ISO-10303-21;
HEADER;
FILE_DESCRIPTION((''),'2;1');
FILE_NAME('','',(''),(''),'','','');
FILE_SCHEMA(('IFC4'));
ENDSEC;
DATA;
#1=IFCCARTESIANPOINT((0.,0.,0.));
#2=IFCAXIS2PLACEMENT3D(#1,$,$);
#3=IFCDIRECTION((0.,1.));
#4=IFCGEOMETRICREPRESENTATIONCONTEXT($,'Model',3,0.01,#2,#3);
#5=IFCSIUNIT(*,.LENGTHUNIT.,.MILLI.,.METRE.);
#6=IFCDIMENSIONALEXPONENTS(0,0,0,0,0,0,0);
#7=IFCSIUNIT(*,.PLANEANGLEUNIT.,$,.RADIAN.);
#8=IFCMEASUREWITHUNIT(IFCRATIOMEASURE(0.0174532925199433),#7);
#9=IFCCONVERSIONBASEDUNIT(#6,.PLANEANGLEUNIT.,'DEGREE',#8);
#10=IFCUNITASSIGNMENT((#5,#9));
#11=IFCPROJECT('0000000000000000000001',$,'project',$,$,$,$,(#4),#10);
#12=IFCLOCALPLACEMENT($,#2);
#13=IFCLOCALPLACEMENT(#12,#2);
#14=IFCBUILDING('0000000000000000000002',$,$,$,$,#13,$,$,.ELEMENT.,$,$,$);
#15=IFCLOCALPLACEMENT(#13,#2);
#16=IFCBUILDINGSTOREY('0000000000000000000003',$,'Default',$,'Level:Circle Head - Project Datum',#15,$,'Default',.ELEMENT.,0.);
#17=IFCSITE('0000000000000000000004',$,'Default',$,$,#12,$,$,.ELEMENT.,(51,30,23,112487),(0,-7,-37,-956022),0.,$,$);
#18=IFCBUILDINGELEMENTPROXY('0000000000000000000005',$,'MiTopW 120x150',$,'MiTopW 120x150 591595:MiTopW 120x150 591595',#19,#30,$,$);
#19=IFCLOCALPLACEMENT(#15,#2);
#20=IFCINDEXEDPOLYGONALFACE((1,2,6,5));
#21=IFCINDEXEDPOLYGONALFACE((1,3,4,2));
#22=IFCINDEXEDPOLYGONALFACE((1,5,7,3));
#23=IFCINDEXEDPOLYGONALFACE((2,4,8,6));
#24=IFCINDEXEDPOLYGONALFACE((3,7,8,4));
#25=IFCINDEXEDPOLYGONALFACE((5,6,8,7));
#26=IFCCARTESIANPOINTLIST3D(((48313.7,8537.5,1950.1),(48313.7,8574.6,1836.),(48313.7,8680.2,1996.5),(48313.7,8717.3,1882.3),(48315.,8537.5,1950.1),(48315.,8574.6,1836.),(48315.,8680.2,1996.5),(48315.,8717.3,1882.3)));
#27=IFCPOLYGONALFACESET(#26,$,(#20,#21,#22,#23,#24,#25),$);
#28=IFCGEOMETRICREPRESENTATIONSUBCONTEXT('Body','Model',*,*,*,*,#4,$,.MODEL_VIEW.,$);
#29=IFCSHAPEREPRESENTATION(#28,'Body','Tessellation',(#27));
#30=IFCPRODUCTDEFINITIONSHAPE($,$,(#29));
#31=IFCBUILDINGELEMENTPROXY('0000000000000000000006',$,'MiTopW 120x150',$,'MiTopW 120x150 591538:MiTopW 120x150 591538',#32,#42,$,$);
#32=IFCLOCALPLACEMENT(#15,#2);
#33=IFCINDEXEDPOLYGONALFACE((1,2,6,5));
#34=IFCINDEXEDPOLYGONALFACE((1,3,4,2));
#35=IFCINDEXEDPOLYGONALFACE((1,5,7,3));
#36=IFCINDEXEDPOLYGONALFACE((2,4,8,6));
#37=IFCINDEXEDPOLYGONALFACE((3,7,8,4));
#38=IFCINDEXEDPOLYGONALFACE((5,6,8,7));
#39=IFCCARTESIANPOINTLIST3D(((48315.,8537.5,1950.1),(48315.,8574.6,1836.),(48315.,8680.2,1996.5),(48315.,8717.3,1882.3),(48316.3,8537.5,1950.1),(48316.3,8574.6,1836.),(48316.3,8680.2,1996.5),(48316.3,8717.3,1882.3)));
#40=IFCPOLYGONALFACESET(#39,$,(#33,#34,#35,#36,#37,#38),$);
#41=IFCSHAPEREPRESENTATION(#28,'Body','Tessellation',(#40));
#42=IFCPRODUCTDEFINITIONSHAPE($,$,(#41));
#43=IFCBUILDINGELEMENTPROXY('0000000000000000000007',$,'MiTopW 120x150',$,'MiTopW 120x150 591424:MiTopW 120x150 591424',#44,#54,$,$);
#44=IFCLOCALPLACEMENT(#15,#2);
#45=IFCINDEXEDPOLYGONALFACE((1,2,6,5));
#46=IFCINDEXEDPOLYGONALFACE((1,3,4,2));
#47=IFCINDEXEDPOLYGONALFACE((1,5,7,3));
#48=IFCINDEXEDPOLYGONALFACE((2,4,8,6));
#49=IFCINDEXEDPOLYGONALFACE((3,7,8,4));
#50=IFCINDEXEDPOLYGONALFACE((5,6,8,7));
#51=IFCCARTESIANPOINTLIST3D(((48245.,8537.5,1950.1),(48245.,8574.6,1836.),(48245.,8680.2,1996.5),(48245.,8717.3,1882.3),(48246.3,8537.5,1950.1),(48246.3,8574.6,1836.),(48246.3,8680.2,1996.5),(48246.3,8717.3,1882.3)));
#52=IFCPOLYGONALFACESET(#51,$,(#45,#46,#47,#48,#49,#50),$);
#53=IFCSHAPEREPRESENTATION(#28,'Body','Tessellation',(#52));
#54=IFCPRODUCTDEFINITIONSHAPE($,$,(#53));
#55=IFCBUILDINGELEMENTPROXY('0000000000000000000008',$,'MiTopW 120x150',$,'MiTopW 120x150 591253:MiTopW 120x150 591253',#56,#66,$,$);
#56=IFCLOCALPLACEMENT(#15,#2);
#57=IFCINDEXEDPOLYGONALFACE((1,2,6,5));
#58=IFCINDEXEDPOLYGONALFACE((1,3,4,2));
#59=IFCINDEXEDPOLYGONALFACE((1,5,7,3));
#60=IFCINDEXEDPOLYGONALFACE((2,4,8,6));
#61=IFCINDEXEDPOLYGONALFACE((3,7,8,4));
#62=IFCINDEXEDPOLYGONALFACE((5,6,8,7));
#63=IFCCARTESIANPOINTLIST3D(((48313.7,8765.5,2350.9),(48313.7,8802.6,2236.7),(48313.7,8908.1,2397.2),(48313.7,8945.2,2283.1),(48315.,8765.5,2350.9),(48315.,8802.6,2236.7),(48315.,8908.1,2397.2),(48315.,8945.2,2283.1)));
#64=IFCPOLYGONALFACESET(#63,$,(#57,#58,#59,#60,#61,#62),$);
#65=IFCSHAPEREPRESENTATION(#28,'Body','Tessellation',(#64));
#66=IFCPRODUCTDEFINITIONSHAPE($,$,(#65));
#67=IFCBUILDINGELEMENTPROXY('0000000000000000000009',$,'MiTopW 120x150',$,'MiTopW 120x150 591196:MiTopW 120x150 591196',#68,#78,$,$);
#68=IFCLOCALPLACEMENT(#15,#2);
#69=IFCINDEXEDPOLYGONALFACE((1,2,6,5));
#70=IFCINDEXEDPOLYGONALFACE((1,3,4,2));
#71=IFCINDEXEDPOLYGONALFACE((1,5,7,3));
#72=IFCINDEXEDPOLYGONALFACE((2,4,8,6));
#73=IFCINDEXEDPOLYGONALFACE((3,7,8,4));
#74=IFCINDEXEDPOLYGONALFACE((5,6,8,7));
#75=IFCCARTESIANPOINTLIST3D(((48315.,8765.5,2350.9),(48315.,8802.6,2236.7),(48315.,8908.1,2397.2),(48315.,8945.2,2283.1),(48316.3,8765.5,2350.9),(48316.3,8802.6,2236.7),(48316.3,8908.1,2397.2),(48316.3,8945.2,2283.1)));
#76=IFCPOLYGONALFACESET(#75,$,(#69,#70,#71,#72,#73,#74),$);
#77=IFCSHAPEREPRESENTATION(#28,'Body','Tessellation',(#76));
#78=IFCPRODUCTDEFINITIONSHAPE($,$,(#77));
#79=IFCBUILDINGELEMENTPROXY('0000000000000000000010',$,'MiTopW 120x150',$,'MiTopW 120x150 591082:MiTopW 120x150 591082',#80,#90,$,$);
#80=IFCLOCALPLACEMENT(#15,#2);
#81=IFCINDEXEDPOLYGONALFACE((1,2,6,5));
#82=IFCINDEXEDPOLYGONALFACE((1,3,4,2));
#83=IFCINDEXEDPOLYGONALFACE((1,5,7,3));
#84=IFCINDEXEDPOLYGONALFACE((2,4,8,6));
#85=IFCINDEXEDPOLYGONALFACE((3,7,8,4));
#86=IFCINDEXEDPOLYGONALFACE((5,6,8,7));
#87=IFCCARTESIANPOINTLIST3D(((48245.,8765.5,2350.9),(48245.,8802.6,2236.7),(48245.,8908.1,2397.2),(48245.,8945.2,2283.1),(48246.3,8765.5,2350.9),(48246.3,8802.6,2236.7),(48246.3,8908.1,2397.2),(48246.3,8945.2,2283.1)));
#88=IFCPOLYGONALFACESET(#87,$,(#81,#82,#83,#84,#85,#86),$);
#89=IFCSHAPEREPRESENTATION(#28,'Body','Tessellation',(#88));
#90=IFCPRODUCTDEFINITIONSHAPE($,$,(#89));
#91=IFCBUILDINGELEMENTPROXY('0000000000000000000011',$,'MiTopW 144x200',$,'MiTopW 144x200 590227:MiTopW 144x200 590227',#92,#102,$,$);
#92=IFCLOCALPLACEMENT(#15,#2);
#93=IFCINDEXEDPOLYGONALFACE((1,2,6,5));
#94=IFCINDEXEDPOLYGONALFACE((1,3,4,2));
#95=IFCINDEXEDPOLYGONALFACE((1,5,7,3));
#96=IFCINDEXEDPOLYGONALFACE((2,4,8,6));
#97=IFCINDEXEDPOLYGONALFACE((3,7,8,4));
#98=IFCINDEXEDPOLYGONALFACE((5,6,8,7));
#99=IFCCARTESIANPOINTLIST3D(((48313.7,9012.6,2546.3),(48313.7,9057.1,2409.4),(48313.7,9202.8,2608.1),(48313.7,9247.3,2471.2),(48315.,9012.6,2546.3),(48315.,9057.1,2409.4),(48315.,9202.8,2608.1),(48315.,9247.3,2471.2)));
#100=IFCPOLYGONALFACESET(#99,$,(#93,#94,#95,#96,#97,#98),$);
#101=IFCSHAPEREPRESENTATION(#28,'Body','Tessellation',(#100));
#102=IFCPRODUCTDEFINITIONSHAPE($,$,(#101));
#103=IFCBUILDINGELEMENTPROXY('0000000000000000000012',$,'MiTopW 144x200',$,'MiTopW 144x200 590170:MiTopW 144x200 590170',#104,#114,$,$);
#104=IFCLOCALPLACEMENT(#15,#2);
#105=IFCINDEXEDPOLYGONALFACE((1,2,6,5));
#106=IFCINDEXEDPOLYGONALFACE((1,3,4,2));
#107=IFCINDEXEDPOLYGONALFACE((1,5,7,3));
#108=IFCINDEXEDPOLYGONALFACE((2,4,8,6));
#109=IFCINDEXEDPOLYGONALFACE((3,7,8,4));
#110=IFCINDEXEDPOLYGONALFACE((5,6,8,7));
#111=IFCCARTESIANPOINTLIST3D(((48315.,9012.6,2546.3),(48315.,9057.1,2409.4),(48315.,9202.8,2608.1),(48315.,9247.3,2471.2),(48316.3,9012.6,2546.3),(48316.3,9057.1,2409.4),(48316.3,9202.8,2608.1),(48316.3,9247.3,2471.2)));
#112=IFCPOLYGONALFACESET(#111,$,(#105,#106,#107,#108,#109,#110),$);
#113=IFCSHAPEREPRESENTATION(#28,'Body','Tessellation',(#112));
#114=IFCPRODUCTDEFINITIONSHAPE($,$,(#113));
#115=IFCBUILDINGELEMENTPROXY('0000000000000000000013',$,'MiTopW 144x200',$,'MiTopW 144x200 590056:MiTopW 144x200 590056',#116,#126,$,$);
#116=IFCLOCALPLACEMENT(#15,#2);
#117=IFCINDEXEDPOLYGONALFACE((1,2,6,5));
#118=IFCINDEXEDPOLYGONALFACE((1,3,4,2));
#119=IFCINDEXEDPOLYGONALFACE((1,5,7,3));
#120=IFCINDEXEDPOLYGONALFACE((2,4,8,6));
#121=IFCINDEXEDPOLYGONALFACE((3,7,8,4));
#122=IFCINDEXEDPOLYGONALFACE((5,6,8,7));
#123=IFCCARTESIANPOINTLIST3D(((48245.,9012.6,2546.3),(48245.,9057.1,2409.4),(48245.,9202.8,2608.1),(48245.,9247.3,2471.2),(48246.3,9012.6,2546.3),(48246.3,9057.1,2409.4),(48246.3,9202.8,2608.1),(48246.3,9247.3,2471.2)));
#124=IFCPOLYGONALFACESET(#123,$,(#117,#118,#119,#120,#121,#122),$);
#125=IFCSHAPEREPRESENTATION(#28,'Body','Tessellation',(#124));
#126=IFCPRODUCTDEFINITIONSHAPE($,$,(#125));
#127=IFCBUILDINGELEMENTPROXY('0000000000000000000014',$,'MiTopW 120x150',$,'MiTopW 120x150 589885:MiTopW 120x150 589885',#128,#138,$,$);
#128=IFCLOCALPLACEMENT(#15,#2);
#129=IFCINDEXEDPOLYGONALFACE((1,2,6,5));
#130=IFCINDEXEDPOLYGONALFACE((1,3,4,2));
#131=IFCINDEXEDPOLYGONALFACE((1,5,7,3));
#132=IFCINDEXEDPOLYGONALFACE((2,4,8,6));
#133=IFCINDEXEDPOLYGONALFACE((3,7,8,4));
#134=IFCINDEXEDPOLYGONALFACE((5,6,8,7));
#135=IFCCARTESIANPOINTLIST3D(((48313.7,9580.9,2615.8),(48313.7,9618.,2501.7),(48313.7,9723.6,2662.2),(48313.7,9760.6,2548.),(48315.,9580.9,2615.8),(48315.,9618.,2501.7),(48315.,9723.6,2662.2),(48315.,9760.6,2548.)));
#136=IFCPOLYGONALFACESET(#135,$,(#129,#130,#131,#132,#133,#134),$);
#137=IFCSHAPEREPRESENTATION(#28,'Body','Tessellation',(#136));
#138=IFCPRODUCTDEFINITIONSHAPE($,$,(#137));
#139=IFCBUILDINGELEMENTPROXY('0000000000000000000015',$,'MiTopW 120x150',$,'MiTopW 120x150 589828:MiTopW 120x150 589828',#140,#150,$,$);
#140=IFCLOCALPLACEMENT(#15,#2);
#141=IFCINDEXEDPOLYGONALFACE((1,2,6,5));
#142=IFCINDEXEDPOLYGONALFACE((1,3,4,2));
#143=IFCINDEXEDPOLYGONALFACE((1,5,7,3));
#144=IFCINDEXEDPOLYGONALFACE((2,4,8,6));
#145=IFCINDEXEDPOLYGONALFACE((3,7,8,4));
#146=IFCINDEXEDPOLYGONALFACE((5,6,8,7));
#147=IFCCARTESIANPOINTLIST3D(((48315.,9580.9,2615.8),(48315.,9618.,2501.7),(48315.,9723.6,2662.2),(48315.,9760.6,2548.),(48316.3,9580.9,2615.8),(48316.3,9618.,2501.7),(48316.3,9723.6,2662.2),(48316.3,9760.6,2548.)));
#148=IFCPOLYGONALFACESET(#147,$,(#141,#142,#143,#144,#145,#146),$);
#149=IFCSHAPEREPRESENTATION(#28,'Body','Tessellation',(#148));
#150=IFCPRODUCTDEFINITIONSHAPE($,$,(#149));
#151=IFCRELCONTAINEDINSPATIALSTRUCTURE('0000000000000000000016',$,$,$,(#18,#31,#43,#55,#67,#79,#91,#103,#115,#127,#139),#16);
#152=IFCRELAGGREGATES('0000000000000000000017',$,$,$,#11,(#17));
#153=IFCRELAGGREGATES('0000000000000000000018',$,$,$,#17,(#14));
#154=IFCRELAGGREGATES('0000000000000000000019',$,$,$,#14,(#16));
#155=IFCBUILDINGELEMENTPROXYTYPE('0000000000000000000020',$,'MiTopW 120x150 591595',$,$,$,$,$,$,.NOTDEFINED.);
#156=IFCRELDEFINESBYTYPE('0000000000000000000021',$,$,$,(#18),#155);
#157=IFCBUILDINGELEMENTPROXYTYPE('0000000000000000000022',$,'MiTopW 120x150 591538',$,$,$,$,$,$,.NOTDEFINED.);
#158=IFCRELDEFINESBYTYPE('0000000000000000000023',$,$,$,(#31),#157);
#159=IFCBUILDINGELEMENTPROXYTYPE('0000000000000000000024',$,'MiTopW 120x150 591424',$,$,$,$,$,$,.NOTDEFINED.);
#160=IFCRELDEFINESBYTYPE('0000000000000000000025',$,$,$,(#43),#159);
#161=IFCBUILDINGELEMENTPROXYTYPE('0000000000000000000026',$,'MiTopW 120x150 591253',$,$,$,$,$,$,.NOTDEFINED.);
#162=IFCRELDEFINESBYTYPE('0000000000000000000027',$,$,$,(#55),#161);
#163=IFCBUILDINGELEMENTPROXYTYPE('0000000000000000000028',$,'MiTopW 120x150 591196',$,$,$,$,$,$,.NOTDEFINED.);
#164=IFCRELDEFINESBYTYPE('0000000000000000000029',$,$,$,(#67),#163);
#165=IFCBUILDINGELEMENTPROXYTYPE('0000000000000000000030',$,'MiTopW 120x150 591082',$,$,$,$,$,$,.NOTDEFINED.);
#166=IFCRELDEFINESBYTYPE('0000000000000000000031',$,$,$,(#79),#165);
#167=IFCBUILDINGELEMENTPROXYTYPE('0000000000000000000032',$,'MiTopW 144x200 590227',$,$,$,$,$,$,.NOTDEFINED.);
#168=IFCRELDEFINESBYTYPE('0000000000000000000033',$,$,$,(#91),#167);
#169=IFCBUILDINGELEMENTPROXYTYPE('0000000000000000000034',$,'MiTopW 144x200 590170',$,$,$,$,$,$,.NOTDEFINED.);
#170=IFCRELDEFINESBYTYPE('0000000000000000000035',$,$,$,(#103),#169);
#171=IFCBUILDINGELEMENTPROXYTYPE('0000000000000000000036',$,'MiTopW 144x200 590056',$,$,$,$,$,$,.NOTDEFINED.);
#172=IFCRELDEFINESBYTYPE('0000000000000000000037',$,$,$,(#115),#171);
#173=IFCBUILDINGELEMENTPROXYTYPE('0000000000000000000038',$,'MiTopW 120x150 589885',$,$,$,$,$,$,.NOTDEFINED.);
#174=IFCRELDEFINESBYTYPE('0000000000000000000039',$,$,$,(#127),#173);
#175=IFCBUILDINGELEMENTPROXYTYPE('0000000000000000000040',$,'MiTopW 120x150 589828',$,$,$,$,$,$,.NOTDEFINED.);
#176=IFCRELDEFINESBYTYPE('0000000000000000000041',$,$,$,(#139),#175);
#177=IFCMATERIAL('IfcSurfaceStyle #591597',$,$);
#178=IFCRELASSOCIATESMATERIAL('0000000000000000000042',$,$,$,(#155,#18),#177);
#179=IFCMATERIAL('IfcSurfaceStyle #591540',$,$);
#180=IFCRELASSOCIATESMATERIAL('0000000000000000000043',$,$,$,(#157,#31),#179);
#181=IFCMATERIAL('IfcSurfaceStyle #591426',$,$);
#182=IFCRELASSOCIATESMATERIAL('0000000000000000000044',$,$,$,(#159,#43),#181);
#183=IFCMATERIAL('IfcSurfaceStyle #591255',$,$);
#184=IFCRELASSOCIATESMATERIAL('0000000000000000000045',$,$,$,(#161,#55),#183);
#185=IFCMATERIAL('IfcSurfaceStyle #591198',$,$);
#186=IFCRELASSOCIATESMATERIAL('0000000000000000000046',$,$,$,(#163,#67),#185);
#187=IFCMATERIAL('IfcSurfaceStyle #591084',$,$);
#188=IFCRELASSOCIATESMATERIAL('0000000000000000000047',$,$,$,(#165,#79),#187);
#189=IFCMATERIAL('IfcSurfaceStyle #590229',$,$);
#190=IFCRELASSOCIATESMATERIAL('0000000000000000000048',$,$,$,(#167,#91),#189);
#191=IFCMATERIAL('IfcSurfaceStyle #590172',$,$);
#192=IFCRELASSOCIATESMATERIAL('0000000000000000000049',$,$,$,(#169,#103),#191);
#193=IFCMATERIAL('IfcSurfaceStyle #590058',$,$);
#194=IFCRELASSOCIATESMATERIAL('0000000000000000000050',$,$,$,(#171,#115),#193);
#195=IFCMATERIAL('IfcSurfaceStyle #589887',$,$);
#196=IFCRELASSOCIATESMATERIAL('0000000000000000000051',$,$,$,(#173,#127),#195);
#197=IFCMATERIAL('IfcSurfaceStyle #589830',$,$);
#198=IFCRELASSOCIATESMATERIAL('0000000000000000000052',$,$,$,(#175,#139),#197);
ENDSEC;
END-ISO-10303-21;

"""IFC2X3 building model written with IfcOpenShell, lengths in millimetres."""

from ifc_helpers import new_model, entity, si_unit, converted_unit, direction, frame, origin, place, context, subcontext, project, spatial, polyline, outline, extrude, source, transform, mapped, material, type_object, type_shapes, element, save


model = new_model("IFC2X3")

# Units and contexts
model_context = context("Model", 3, precision=0.01, world=origin(), true_north=direction((0.0, 1.0)))
body_context = subcontext(model_context, "Body", "Model", "MODEL_VIEW")
ifc_project = project(units=[si_unit("LENGTHUNIT", "METRE", prefix="MILLI"), converted_unit("PLANEANGLEUNIT", "DEGREE", entity("IfcRatioMeasure", 0.0174532925199433), si_unit("PLANEANGLEUNIT", "RADIAN"), dimensions=[0, 0, 0, 0, 0, 0, 0])], contexts=[model_context])

# Site, building, storey
site_placement = place(None, origin())
site = spatial("IfcSite", under=ifc_project, at=site_placement, Name="Default", CompositionType="ELEMENT", RefLatitude=(51, 30, 23, 112487), RefLongitude=(0, -7, -37, -956022), RefElevation=0.0)
building_placement = place(site_placement, origin())
building = spatial("IfcBuilding", under=site, at=building_placement, CompositionType="ELEMENT")
storey_placement = place(building_placement, origin())
storey = spatial("IfcBuildingStorey", under=building, at=storey_placement, Name="Default", ObjectType="Level:Circle Head - Project Datum", LongName="Default", CompositionType="ELEMENT", Elevation=0.0)

# Building element proxies
ifc_material_1 = material(Name="IfcSurfaceStyle #591597")
building_element_proxy_type_1 = type_object("IfcBuildingElementProxyType", Name="MiTopW 120x150 591595", PredefinedType="NOTDEFINED", material=ifc_material_1)
shared_shape_1 = source(origin(), body_context, "Body", "SweptSolid", [
    extrude(outline(polyline([(-75.0, -60.0), (75.0, -60.0), (75.0, 60.0), (-75.0, 60.0), (-75.0, -60.0)])), frame((75.0, 60.0, 0.0), z_axis=(0.0, 0.0, 1.0), x_axis=(-1.0, 0.0, 0.0)), (0.0, 0.0, 1.0), 1.3),
])
type_shapes(building_element_proxy_type_1, [shared_shape_1])
proxy_1_placement = place(building_placement, frame((48315.0, 8537.5, 1950.1), z_axis=(-1.0, 0.0, 0.0), x_axis=(0.0, 0.951057, 0.309017)))
element("IfcBuildingElementProxy", 1, at=proxy_1_placement, inside=storey, type_object=building_element_proxy_type_1, material=ifc_material_1, Name="MiTopW 120x150", ObjectType="MiTopW 120x150 591595:MiTopW 120x150 591595", context=body_context, shape_type="MappedRepresentation", body=[
    mapped(shared_shape_1, transform((0.0, 0.0, 0.0), scale=1.0)),
])
ifc_material_2 = material(Name="IfcSurfaceStyle #591540")
building_element_proxy_type_2 = type_object("IfcBuildingElementProxyType", Name="MiTopW 120x150 591538", PredefinedType="NOTDEFINED", material=ifc_material_2)
shared_shape_2 = source(origin(), body_context, "Body", "SweptSolid", [
    extrude(outline(polyline([(-75.0, -60.0), (75.0, -60.0), (75.0, 60.0), (-75.0, 60.0), (-75.0, -60.0)])), frame((75.0, 60.0, 0.0), z_axis=(0.0, 0.0, 1.0), x_axis=(-1.0, 0.0, 0.0)), (0.0, 0.0, 1.0), 1.3),
])
type_shapes(building_element_proxy_type_2, [shared_shape_2])
proxy_2_placement = place(building_placement, frame((48316.3, 8537.5, 1950.1), z_axis=(-1.0, 0.0, 0.0), x_axis=(0.0, 0.951057, 0.309017)))
element("IfcBuildingElementProxy", 2, at=proxy_2_placement, inside=storey, type_object=building_element_proxy_type_2, material=ifc_material_2, Name="MiTopW 120x150", ObjectType="MiTopW 120x150 591538:MiTopW 120x150 591538", context=body_context, shape_type="MappedRepresentation", body=[
    mapped(shared_shape_2, transform((0.0, 0.0, 0.0), scale=1.0)),
])
ifc_material_3 = material(Name="IfcSurfaceStyle #591426")
building_element_proxy_type_3 = type_object("IfcBuildingElementProxyType", Name="MiTopW 120x150 591424", PredefinedType="NOTDEFINED", material=ifc_material_3)
shared_shape_3 = source(origin(), body_context, "Body", "SweptSolid", [
    extrude(outline(polyline([(-75.0, -60.0), (75.0, -60.0), (75.0, 60.0), (-75.0, 60.0), (-75.0, -60.0)])), frame((75.0, 60.0, 0.0), z_axis=(0.0, 0.0, 1.0), x_axis=(-1.0, 0.0, 0.0)), (0.0, 0.0, 1.0), 1.3),
])
type_shapes(building_element_proxy_type_3, [shared_shape_3])
proxy_3_placement = place(building_placement, frame((48246.3, 8537.5, 1950.1), z_axis=(-1.0, 0.0, 0.0), x_axis=(0.0, 0.951057, 0.309017)))
element("IfcBuildingElementProxy", 3, at=proxy_3_placement, inside=storey, type_object=building_element_proxy_type_3, material=ifc_material_3, Name="MiTopW 120x150", ObjectType="MiTopW 120x150 591424:MiTopW 120x150 591424", context=body_context, shape_type="MappedRepresentation", body=[
    mapped(shared_shape_3, transform((0.0, 0.0, 0.0), scale=1.0)),
])
ifc_material_4 = material(Name="IfcSurfaceStyle #591255")
building_element_proxy_type_4 = type_object("IfcBuildingElementProxyType", Name="MiTopW 120x150 591253", PredefinedType="NOTDEFINED", material=ifc_material_4)
shared_shape_4 = source(origin(), body_context, "Body", "SweptSolid", [
    extrude(outline(polyline([(-75.0, -60.0), (75.0, -60.0), (75.0, 60.0), (-75.0, 60.0), (-75.0, -60.0)])), frame((75.0, 60.0, 0.0), z_axis=(0.0, 0.0, 1.0), x_axis=(-1.0, 0.0, 0.0)), (0.0, 0.0, 1.0), 1.3),
])
type_shapes(building_element_proxy_type_4, [shared_shape_4])
proxy_4_placement = place(building_placement, frame((48315.0, 8765.5, 2350.9), z_axis=(-1.0, 0.0, 0.0), x_axis=(0.0, 0.951057, 0.309017)))
element("IfcBuildingElementProxy", 4, at=proxy_4_placement, inside=storey, type_object=building_element_proxy_type_4, material=ifc_material_4, Name="MiTopW 120x150", ObjectType="MiTopW 120x150 591253:MiTopW 120x150 591253", context=body_context, shape_type="MappedRepresentation", body=[
    mapped(shared_shape_4, transform((0.0, 0.0, 0.0), scale=1.0)),
])
ifc_material_5 = material(Name="IfcSurfaceStyle #591198")
building_element_proxy_type_5 = type_object("IfcBuildingElementProxyType", Name="MiTopW 120x150 591196", PredefinedType="NOTDEFINED", material=ifc_material_5)
shared_shape_5 = source(origin(), body_context, "Body", "SweptSolid", [
    extrude(outline(polyline([(-75.0, -60.0), (75.0, -60.0), (75.0, 60.0), (-75.0, 60.0), (-75.0, -60.0)])), frame((75.0, 60.0, 0.0), z_axis=(0.0, 0.0, 1.0), x_axis=(-1.0, 0.0, 0.0)), (0.0, 0.0, 1.0), 1.3),
])
type_shapes(building_element_proxy_type_5, [shared_shape_5])
proxy_5_placement = place(building_placement, frame((48316.3, 8765.5, 2350.9), z_axis=(-1.0, 0.0, 0.0), x_axis=(0.0, 0.951057, 0.309017)))
element("IfcBuildingElementProxy", 5, at=proxy_5_placement, inside=storey, type_object=building_element_proxy_type_5, material=ifc_material_5, Name="MiTopW 120x150", ObjectType="MiTopW 120x150 591196:MiTopW 120x150 591196", context=body_context, shape_type="MappedRepresentation", body=[
    mapped(shared_shape_5, transform((0.0, 0.0, 0.0), scale=1.0)),
])
ifc_material_6 = material(Name="IfcSurfaceStyle #591084")
building_element_proxy_type_6 = type_object("IfcBuildingElementProxyType", Name="MiTopW 120x150 591082", PredefinedType="NOTDEFINED", material=ifc_material_6)
shared_shape_6 = source(origin(), body_context, "Body", "SweptSolid", [
    extrude(outline(polyline([(-75.0, -60.0), (75.0, -60.0), (75.0, 60.0), (-75.0, 60.0), (-75.0, -60.0)])), frame((75.0, 60.0, 0.0), z_axis=(0.0, 0.0, 1.0), x_axis=(-1.0, 0.0, 0.0)), (0.0, 0.0, 1.0), 1.3),
])
type_shapes(building_element_proxy_type_6, [shared_shape_6])
proxy_6_placement = place(building_placement, frame((48246.3, 8765.5, 2350.9), z_axis=(-1.0, 0.0, 0.0), x_axis=(0.0, 0.951057, 0.309017)))
element("IfcBuildingElementProxy", 6, at=proxy_6_placement, inside=storey, type_object=building_element_proxy_type_6, material=ifc_material_6, Name="MiTopW 120x150", ObjectType="MiTopW 120x150 591082:MiTopW 120x150 591082", context=body_context, shape_type="MappedRepresentation", body=[
    mapped(shared_shape_6, transform((0.0, 0.0, 0.0), scale=1.0)),
])
ifc_material_7 = material(Name="IfcSurfaceStyle #590229")
building_element_proxy_type_7 = type_object("IfcBuildingElementProxyType", Name="MiTopW 144x200 590227", PredefinedType="NOTDEFINED", material=ifc_material_7)
shared_shape_7 = source(origin(), body_context, "Body", "SweptSolid", [
    extrude(outline(polyline([(-100.0, -72.0), (100.0, -72.0), (100.0, 72.0), (-100.0, 72.0), (-100.0, -72.0)])), frame((100.0, 72.0, 0.0), z_axis=(0.0, 0.0, 1.0), x_axis=(-1.0, 0.0, 0.0)), (0.0, 0.0, 1.0), 1.3),
])
type_shapes(building_element_proxy_type_7, [shared_shape_7])
proxy_7_placement = place(building_placement, frame((48315.0, 9012.6, 2546.3), z_axis=(-1.0, 0.0, 0.0), x_axis=(0.0, 0.951057, 0.309017)))
element("IfcBuildingElementProxy", 7, at=proxy_7_placement, inside=storey, type_object=building_element_proxy_type_7, material=ifc_material_7, Name="MiTopW 144x200", ObjectType="MiTopW 144x200 590227:MiTopW 144x200 590227", context=body_context, shape_type="MappedRepresentation", body=[
    mapped(shared_shape_7, transform((0.0, 0.0, 0.0), scale=1.0)),
])
ifc_material_8 = material(Name="IfcSurfaceStyle #590172")
building_element_proxy_type_8 = type_object("IfcBuildingElementProxyType", Name="MiTopW 144x200 590170", PredefinedType="NOTDEFINED", material=ifc_material_8)
shared_shape_8 = source(origin(), body_context, "Body", "SweptSolid", [
    extrude(outline(polyline([(-100.0, -72.0), (100.0, -72.0), (100.0, 72.0), (-100.0, 72.0), (-100.0, -72.0)])), frame((100.0, 72.0, 0.0), z_axis=(0.0, 0.0, 1.0), x_axis=(-1.0, 0.0, 0.0)), (0.0, 0.0, 1.0), 1.3),
])
type_shapes(building_element_proxy_type_8, [shared_shape_8])
proxy_8_placement = place(building_placement, frame((48316.3, 9012.6, 2546.3), z_axis=(-1.0, 0.0, 0.0), x_axis=(0.0, 0.951057, 0.309017)))
element("IfcBuildingElementProxy", 8, at=proxy_8_placement, inside=storey, type_object=building_element_proxy_type_8, material=ifc_material_8, Name="MiTopW 144x200", ObjectType="MiTopW 144x200 590170:MiTopW 144x200 590170", context=body_context, shape_type="MappedRepresentation", body=[
    mapped(shared_shape_8, transform((0.0, 0.0, 0.0), scale=1.0)),
])
ifc_material_9 = material(Name="IfcSurfaceStyle #590058")
building_element_proxy_type_9 = type_object("IfcBuildingElementProxyType", Name="MiTopW 144x200 590056", PredefinedType="NOTDEFINED", material=ifc_material_9)
shared_shape_9 = source(origin(), body_context, "Body", "SweptSolid", [
    extrude(outline(polyline([(-100.0, -72.0), (100.0, -72.0), (100.0, 72.0), (-100.0, 72.0), (-100.0, -72.0)])), frame((100.0, 72.0, 0.0), z_axis=(0.0, 0.0, 1.0), x_axis=(-1.0, 0.0, 0.0)), (0.0, 0.0, 1.0), 1.3),
])
type_shapes(building_element_proxy_type_9, [shared_shape_9])
proxy_9_placement = place(building_placement, frame((48246.3, 9012.6, 2546.3), z_axis=(-1.0, 0.0, 0.0), x_axis=(0.0, 0.951057, 0.309017)))
element("IfcBuildingElementProxy", 9, at=proxy_9_placement, inside=storey, type_object=building_element_proxy_type_9, material=ifc_material_9, Name="MiTopW 144x200", ObjectType="MiTopW 144x200 590056:MiTopW 144x200 590056", context=body_context, shape_type="MappedRepresentation", body=[
    mapped(shared_shape_9, transform((0.0, 0.0, 0.0), scale=1.0)),
])
ifc_material_10 = material(Name="IfcSurfaceStyle #589887")
building_element_proxy_type_10 = type_object("IfcBuildingElementProxyType", Name="MiTopW 120x150 589885", PredefinedType="NOTDEFINED", material=ifc_material_10)
shared_shape_10 = source(origin(), body_context, "Body", "SweptSolid", [
    extrude(outline(polyline([(-75.0, -60.0), (75.0, -60.0), (75.0, 60.0), (-75.0, 60.0), (-75.0, -60.0)])), frame((75.0, 60.0, 0.0), z_axis=(0.0, 0.0, 1.0), x_axis=(-1.0, 0.0, 0.0)), (0.0, 0.0, 1.0), 1.3),
])
type_shapes(building_element_proxy_type_10, [shared_shape_10])
proxy_10_placement = place(building_placement, frame((48315.0, 9580.9, 2615.8), z_axis=(-1.0, 0.0, 0.0), x_axis=(0.0, 0.951057, 0.309017)))
element("IfcBuildingElementProxy", 10, at=proxy_10_placement, inside=storey, type_object=building_element_proxy_type_10, material=ifc_material_10, Name="MiTopW 120x150", ObjectType="MiTopW 120x150 589885:MiTopW 120x150 589885", context=body_context, shape_type="MappedRepresentation", body=[
    mapped(shared_shape_10, transform((0.0, 0.0, 0.0), scale=1.0)),
])
ifc_material_11 = material(Name="IfcSurfaceStyle #589830")
building_element_proxy_type_11 = type_object("IfcBuildingElementProxyType", Name="MiTopW 120x150 589828", PredefinedType="NOTDEFINED", material=ifc_material_11)
shared_shape_11 = source(origin(), body_context, "Body", "SweptSolid", [
    extrude(outline(polyline([(-75.0, -60.0), (75.0, -60.0), (75.0, 60.0), (-75.0, 60.0), (-75.0, -60.0)])), frame((75.0, 60.0, 0.0), z_axis=(0.0, 0.0, 1.0), x_axis=(-1.0, 0.0, 0.0)), (0.0, 0.0, 1.0), 1.3),
])
type_shapes(building_element_proxy_type_11, [shared_shape_11])
proxy_11_placement = place(building_placement, frame((48316.3, 9580.9, 2615.8), z_axis=(-1.0, 0.0, 0.0), x_axis=(0.0, 0.951057, 0.309017)))
element("IfcBuildingElementProxy", 11, at=proxy_11_placement, inside=storey, type_object=building_element_proxy_type_11, material=ifc_material_11, Name="MiTopW 120x150", ObjectType="MiTopW 120x150 589828:MiTopW 120x150 589828", context=body_context, shape_type="MappedRepresentation", body=[
    mapped(shared_shape_11, transform((0.0, 0.0, 0.0), scale=1.0)),
])

save(model, "model.ifc")
